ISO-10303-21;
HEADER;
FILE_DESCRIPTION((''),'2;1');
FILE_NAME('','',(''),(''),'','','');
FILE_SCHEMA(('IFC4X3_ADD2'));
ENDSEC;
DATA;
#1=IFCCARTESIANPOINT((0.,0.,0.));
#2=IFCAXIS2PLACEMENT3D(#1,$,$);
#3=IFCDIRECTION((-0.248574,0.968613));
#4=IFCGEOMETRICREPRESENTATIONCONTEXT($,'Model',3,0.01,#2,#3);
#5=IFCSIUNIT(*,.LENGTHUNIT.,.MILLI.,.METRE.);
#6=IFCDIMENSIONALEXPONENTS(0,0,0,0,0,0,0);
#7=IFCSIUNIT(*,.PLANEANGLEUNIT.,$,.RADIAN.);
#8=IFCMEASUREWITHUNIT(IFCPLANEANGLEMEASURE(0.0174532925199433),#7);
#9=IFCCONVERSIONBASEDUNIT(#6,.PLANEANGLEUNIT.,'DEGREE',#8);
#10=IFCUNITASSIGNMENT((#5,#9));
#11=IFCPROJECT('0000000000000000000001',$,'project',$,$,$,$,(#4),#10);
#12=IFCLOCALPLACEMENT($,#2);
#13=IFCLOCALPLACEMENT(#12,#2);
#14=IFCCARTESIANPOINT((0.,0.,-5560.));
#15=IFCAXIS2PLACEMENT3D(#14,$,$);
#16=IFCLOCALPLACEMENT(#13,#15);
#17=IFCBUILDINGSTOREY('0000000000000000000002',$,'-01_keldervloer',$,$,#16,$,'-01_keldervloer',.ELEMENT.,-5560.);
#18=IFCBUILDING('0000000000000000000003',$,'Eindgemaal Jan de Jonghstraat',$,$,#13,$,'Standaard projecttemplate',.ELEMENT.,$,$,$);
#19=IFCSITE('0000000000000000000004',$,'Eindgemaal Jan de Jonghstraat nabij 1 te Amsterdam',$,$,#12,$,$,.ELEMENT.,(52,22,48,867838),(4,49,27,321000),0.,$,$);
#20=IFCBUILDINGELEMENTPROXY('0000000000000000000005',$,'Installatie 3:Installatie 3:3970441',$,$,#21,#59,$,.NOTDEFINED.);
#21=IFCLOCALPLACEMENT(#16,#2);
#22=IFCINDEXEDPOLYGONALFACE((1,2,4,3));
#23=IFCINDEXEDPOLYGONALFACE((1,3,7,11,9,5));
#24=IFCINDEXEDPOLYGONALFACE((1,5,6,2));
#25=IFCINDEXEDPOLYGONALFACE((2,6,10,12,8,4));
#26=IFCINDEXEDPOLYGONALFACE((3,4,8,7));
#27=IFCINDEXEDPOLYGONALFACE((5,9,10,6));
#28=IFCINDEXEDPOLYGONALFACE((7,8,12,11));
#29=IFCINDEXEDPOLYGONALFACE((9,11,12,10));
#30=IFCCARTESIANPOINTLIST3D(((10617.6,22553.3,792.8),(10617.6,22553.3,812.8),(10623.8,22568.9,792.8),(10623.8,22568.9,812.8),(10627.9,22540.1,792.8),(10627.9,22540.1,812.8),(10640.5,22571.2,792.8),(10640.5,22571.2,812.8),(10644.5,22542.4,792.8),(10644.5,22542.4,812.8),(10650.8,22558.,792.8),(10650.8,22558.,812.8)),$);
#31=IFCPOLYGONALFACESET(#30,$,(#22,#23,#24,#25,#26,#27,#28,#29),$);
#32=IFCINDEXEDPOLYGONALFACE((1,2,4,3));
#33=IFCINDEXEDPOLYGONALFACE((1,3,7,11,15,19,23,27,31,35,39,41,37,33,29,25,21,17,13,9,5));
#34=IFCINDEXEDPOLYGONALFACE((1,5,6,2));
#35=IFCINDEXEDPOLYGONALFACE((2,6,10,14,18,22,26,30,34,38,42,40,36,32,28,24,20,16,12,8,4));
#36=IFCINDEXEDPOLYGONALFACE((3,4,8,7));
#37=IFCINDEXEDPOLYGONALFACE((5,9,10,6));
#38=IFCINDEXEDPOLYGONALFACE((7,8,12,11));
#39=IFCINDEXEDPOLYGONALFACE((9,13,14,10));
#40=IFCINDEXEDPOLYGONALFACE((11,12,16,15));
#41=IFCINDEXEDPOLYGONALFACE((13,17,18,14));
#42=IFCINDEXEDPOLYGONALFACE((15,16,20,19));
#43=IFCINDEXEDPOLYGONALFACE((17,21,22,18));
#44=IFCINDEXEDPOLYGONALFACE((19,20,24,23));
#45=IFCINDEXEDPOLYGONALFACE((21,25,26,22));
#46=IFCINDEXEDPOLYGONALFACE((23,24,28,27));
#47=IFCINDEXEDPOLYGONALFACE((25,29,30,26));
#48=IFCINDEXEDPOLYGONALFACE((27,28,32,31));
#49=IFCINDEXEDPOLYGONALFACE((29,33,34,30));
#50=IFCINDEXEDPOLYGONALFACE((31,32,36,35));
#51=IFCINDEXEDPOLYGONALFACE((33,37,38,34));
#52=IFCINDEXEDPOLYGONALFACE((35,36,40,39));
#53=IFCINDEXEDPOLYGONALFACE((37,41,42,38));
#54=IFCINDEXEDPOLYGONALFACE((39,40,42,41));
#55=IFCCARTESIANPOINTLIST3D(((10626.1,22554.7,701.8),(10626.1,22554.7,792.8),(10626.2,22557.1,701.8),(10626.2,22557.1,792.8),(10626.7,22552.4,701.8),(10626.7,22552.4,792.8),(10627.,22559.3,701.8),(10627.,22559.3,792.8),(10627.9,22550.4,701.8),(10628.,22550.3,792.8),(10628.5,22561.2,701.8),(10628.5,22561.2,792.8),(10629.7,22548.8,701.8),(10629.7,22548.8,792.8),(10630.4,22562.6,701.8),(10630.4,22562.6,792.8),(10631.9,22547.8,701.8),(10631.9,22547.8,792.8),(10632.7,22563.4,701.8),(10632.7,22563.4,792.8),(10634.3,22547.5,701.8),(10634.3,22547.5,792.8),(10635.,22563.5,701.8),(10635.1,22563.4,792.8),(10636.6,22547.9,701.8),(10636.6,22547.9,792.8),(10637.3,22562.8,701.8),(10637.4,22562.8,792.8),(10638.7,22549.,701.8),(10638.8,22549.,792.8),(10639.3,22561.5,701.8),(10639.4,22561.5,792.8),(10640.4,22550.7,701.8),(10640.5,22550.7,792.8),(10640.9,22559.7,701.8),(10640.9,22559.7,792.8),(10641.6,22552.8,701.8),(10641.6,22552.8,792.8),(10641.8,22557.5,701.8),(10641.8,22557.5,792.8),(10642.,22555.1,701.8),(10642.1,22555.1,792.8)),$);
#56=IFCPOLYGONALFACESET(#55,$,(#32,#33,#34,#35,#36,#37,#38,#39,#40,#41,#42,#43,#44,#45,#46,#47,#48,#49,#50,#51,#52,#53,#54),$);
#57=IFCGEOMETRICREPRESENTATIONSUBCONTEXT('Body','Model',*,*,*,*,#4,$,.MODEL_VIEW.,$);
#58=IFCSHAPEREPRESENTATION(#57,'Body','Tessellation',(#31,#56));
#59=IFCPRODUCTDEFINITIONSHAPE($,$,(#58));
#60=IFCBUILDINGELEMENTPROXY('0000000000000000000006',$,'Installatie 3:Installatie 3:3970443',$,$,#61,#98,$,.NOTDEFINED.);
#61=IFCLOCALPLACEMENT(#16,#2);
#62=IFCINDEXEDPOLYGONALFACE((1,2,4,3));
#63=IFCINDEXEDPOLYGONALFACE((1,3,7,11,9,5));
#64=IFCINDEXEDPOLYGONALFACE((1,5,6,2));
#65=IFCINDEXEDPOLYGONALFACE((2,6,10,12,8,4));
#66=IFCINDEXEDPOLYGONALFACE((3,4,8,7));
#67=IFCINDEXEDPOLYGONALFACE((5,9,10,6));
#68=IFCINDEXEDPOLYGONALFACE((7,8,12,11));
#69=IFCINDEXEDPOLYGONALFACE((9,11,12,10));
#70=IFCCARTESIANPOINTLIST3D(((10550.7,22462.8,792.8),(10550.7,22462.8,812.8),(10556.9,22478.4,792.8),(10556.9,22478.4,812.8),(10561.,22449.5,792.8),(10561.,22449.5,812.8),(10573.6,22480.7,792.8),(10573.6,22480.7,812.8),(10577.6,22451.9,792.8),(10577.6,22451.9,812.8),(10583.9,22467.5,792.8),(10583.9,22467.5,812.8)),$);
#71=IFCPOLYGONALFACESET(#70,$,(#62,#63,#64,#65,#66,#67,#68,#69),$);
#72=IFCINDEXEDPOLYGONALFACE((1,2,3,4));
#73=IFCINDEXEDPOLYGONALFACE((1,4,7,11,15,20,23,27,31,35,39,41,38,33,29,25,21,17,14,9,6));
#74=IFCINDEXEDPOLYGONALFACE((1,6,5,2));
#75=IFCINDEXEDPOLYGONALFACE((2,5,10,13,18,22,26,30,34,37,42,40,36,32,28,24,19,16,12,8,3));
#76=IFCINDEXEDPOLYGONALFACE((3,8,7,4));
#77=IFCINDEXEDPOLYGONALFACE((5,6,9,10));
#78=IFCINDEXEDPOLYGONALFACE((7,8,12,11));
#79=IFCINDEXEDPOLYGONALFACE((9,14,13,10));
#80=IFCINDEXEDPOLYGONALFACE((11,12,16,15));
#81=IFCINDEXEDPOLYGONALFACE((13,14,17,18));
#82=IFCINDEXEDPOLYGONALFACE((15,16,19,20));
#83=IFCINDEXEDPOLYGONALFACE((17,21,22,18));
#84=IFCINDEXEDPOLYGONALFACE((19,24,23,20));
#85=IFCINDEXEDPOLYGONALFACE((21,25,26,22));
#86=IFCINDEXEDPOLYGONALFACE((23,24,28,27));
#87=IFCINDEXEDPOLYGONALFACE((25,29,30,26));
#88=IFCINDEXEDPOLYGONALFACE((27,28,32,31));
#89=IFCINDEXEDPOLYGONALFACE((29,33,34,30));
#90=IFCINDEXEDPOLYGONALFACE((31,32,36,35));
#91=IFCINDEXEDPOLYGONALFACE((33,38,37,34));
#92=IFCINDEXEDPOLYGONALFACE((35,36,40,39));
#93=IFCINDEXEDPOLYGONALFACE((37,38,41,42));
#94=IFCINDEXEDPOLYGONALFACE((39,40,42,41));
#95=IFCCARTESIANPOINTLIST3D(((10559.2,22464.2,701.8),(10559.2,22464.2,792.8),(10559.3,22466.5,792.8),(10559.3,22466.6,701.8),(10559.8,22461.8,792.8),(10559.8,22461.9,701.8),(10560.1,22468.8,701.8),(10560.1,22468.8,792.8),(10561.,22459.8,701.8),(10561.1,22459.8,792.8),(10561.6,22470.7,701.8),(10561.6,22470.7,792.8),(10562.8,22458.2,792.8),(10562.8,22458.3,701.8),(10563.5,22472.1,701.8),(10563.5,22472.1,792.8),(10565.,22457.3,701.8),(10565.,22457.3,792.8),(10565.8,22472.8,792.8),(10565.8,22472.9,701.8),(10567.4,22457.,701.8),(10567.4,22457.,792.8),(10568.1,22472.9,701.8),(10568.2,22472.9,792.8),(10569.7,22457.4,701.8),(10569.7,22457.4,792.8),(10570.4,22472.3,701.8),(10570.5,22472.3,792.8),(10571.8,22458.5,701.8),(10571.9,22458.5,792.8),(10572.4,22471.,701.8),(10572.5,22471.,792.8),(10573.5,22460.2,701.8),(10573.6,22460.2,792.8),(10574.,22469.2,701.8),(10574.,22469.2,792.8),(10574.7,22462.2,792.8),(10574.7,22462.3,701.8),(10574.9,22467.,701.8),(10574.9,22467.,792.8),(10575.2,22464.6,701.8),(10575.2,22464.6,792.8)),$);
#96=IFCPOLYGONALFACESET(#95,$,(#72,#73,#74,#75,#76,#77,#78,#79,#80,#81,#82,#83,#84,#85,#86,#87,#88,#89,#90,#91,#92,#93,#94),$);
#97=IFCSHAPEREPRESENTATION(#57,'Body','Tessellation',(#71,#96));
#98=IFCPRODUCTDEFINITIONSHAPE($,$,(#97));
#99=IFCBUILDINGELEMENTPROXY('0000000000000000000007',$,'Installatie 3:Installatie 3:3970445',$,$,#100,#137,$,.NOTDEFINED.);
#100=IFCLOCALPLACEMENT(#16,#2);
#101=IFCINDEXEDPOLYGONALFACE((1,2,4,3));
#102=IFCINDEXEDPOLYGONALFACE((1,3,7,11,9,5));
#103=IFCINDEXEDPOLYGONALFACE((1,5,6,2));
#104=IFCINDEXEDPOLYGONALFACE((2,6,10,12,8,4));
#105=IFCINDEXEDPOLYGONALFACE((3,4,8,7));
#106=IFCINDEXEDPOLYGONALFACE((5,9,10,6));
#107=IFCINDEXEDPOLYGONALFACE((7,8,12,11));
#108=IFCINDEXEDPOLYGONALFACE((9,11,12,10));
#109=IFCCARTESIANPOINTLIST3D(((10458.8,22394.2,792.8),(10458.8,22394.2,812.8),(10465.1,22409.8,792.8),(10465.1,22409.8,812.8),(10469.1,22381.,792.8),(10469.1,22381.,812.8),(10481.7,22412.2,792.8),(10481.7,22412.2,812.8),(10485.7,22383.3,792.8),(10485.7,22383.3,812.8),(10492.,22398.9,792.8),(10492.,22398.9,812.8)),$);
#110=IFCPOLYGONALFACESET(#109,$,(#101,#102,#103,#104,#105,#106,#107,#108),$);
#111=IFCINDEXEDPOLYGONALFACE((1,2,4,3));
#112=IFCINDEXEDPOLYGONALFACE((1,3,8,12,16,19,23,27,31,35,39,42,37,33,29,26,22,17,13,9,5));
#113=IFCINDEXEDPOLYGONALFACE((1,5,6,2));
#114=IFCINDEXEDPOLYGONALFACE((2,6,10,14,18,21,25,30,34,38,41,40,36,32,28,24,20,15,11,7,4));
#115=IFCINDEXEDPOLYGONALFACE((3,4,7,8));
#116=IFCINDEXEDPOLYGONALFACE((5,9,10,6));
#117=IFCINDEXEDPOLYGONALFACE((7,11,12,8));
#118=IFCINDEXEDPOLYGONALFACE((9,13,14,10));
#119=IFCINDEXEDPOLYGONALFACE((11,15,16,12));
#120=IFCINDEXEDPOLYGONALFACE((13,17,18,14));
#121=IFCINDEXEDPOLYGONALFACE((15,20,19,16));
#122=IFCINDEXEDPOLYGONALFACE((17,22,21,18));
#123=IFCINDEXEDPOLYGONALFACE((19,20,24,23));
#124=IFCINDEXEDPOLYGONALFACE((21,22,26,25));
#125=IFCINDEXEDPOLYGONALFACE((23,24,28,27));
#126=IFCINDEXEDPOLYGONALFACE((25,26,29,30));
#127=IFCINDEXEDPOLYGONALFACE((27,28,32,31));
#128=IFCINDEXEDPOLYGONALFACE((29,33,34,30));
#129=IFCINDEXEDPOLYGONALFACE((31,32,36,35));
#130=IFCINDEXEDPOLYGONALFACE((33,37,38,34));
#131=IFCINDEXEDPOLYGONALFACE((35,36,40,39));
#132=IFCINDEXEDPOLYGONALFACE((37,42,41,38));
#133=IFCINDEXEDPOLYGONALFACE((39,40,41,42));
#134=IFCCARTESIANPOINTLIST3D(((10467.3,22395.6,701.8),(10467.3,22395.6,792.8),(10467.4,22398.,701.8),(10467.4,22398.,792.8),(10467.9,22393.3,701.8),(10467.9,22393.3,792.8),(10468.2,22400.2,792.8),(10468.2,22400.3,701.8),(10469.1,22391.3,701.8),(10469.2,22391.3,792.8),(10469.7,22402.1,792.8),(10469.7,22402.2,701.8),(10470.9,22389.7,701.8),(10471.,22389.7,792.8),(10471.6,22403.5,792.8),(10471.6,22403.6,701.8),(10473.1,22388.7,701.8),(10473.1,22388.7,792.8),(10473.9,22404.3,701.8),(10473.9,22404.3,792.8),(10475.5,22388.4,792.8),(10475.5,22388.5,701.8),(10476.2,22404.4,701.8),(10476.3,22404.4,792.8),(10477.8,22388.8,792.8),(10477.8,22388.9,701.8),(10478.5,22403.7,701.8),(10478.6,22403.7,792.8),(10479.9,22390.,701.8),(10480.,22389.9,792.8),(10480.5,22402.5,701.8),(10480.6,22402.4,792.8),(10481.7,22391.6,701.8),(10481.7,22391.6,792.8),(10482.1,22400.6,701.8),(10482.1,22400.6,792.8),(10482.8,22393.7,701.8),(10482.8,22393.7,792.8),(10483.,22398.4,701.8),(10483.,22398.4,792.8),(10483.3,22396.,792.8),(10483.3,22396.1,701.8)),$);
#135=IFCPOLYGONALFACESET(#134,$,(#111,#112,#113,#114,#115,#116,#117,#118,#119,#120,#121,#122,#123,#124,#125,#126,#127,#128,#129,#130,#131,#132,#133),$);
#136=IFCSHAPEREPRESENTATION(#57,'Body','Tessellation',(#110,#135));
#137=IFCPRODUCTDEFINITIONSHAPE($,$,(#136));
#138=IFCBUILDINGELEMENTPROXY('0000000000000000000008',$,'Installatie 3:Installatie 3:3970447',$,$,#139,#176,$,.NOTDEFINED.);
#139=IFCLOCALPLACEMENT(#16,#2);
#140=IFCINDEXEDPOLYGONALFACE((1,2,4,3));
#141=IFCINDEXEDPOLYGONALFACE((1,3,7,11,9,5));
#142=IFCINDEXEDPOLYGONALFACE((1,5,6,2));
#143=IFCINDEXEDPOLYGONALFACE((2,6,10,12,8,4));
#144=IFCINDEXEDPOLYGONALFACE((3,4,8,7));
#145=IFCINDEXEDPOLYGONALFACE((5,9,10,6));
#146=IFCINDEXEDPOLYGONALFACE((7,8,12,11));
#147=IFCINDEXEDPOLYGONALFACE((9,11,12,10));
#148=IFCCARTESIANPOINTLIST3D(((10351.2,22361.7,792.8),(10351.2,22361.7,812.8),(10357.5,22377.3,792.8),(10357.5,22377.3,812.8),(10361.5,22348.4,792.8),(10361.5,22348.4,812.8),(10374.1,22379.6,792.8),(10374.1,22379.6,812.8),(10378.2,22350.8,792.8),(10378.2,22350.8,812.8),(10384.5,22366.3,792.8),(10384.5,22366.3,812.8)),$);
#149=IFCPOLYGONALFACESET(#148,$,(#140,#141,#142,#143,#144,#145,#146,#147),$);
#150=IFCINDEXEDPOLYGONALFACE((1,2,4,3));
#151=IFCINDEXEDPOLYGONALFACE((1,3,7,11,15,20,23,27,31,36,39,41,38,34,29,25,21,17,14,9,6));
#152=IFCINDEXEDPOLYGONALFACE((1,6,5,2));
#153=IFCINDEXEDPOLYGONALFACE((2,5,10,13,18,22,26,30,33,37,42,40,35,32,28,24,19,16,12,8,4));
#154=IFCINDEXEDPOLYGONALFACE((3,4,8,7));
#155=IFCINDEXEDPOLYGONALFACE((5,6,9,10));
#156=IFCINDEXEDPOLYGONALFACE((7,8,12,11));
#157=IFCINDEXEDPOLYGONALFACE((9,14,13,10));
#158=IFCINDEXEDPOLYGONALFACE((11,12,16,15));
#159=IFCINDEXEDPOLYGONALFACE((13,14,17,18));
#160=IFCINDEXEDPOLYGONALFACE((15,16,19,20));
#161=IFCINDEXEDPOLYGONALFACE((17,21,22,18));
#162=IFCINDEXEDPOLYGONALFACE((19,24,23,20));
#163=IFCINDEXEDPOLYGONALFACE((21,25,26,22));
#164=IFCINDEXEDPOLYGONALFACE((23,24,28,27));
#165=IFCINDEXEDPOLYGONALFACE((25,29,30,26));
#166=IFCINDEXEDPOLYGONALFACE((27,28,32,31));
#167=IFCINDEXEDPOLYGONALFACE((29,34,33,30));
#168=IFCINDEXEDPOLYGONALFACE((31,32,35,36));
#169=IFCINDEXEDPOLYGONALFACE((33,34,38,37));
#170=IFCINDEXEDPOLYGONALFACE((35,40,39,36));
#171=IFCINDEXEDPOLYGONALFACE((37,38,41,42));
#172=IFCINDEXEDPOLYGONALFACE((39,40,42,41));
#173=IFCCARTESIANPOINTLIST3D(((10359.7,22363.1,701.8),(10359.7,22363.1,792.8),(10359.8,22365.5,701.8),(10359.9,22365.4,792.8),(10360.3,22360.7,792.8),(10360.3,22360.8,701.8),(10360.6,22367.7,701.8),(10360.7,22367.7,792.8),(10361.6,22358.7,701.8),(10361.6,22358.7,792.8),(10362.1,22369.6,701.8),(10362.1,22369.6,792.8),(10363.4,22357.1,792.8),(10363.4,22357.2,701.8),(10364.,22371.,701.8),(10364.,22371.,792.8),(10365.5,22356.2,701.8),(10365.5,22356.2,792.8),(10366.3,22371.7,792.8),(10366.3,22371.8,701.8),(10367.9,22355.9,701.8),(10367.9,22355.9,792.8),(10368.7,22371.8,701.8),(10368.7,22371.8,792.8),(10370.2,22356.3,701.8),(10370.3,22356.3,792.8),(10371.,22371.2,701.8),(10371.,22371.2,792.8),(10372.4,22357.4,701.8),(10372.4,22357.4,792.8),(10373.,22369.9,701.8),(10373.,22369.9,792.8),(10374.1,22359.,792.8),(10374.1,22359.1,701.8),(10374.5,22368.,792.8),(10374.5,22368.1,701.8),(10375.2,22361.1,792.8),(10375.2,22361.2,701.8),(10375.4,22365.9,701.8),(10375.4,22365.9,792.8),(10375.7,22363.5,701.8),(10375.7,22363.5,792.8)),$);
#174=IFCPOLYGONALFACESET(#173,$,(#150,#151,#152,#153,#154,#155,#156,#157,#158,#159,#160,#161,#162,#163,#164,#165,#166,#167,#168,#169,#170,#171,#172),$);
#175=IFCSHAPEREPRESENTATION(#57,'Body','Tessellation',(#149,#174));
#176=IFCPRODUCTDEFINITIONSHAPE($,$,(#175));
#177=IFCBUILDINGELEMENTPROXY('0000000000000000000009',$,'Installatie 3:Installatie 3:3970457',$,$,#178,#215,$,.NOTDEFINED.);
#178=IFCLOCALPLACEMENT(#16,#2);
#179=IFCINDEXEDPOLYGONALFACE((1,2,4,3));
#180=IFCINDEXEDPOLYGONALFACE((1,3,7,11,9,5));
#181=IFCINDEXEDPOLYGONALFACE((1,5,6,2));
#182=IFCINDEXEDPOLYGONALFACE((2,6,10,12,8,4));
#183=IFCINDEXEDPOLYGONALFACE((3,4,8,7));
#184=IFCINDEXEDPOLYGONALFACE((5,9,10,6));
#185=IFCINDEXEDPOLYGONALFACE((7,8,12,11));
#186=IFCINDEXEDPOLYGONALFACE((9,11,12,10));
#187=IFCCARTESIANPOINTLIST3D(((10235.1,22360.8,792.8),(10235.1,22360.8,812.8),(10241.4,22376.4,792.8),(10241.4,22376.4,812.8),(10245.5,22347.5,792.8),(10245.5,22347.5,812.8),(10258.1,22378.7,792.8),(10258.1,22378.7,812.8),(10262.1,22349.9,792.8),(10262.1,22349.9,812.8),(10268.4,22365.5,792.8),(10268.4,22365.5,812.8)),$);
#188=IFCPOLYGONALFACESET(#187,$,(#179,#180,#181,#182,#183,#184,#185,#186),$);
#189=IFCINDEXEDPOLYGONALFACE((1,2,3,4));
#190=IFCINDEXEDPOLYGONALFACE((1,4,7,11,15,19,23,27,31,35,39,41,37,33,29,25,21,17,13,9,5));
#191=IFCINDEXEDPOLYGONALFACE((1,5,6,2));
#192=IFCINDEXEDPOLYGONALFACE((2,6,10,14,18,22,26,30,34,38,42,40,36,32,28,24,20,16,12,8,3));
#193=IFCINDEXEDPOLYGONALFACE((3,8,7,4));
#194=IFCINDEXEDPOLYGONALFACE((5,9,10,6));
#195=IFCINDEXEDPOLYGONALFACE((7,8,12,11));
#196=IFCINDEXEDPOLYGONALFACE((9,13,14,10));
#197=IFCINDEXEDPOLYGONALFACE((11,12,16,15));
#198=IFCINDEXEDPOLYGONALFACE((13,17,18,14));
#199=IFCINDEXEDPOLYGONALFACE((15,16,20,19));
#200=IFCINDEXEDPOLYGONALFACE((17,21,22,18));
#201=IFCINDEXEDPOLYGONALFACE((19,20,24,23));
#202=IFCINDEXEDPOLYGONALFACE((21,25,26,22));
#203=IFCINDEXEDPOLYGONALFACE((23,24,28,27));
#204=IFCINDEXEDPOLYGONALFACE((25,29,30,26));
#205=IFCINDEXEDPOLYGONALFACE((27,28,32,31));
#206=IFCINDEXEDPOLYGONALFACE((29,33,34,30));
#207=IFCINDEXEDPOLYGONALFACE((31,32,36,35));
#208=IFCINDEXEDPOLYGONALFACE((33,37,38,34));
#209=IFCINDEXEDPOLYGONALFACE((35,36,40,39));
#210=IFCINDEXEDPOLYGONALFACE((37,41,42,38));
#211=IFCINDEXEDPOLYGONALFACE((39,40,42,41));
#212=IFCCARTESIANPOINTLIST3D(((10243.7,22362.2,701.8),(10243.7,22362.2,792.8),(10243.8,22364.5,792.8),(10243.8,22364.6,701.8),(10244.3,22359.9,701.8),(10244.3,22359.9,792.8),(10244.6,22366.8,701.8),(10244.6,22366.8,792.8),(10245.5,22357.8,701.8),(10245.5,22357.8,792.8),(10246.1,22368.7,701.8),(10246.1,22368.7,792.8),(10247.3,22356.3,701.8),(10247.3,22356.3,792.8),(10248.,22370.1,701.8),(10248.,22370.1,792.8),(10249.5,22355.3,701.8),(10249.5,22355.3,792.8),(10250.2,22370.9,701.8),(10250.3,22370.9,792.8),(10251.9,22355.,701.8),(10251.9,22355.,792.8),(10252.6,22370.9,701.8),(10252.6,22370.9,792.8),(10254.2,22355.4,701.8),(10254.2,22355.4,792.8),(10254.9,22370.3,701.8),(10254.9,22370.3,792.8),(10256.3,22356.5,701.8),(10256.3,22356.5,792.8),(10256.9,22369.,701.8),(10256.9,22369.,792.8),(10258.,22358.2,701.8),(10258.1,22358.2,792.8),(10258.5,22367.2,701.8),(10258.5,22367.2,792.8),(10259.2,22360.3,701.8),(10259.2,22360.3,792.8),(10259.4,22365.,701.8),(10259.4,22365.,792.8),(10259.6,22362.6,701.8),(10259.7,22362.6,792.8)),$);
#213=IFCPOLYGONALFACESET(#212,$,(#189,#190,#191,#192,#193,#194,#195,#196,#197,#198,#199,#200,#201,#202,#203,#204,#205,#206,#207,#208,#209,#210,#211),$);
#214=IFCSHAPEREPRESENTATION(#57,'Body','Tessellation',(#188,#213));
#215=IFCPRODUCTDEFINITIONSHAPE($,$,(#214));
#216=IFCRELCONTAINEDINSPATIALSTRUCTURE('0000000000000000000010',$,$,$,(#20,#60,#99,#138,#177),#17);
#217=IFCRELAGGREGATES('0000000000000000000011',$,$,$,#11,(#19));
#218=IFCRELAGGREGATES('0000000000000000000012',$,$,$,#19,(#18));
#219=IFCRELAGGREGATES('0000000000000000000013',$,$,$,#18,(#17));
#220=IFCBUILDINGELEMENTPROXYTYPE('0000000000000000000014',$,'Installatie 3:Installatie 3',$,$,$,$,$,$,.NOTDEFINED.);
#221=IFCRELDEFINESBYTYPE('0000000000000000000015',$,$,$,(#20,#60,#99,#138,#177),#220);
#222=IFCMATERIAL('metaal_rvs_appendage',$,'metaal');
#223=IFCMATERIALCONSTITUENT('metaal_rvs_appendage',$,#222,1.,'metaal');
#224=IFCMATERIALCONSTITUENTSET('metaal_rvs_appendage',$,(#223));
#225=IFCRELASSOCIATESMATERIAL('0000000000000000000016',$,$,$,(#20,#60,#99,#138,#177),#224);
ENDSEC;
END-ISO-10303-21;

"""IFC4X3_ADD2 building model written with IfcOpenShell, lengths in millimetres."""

from ifc_helpers import new_model, entity, si_unit, converted_unit, direction, frame, frame_2d, origin, place, context, subcontext, project, spatial, polyline, circle, outline, extrude, source, transform, mapped, material, constituent, constituent_set, type_object, type_shapes, element, save


model = new_model("IFC4X3_ADD2")

# Units and contexts
model_context = context("Model", 3, precision=0.01, world=origin(), true_north=direction((-0.248574, 0.968613)))
body_context = subcontext(model_context, "Body", "Model", "MODEL_VIEW")
ifc_project = project(units=[si_unit("LENGTHUNIT", "METRE", prefix="MILLI"), converted_unit("PLANEANGLEUNIT", "DEGREE", entity("IfcPlaneAngleMeasure", 0.0174532925199433), si_unit("PLANEANGLEUNIT", "RADIAN"), dimensions=[0, 0, 0, 0, 0, 0, 0])], contexts=[model_context])

# Site, building, storey
site_placement = place(None, origin())
site = spatial("IfcSite", under=ifc_project, at=site_placement, Name="Eindgemaal Jan de Jonghstraat nabij 1 te Amsterdam", CompositionType="ELEMENT", RefLatitude=(52, 22, 48, 867838), RefLongitude=(4, 49, 27, 321000), RefElevation=0.0)
building_placement = place(site_placement, origin())
building = spatial("IfcBuilding", under=site, at=building_placement, Name="Eindgemaal Jan de Jonghstraat", LongName="Standaard projecttemplate", CompositionType="ELEMENT")
storey_placement = place(building_placement, frame((0.0, 0.0, -5560.0)))
storey = spatial("IfcBuildingStorey", under=building, at=storey_placement, Name="-01_keldervloer", LongName="-01_keldervloer", CompositionType="ELEMENT", Elevation=-5560.0)

# Building element proxies
ifc_material_1 = material(Name="metaal_rvs_appendage", Category="metaal")
ifc_constituent_1 = constituent(ifc_material_1, Name="metaal_rvs_appendage", Category="metaal", fraction=1.0)
ifc_constituent_set_1 = constituent_set(constituents=[ifc_constituent_1], Name="metaal_rvs_appendage")
building_element_proxy_type_1 = type_object("IfcBuildingElementProxyType", Name="Installatie 3:Installatie 3", PredefinedType="NOTDEFINED")
shared_shape_1 = source(origin(), body_context, "Body", "SweptSolid", [
    extrude(outline(polyline([(-8.4, -14.6), (8.4, -14.6), (16.8, 0.0), (8.4, 14.6), (-8.4, 14.6), (-16.8, 0.0), (-8.4, -14.6)])), frame((0.0, 0.0, 41.5), z_axis=(0.0, 0.0, 1.0), x_axis=(-0.400458, 0.916315, 0.0)), (0.0, 0.0, 1.0), 20.0),
    extrude(circle(Radius=8.0, at=frame_2d((0.0, 0.0), x_axis=(1.0, 0.0))), frame((-0.2, -0.1, -49.5), z_axis=(0.000101, -0.000286, 1.0), x_axis=(1.0, 0.0, -0.000101)), (0.0, 0.0, 1.0), 91.1),
])
type_shapes(building_element_proxy_type_1, [shared_shape_1])
for number, where, z_axis, x_axis, name in (
    (1, (10634.2, 22555.6, 751.3), (0.0, 0.0, 1.0), (0.968613, 0.248574, 0.0), "Installatie 3:Installatie 3:3970441"),
    (2, (10567.3, 22465.1, 751.3), (0.0, 0.0, 1.0), (0.968613, 0.248574, 0.0), "Installatie 3:Installatie 3:3970443"),
    (3, (10475.4, 22396.6, 751.3), (0.0, 0.0, 1.0), (0.968613, 0.248574, 0.0), "Installatie 3:Installatie 3:3970445"),
    (4, (10367.8, 22364.0, 751.3), (0.0, 0.0, 1.0), (0.968613, 0.248574, 0.0), "Installatie 3:Installatie 3:3970447"),
    (5, (10251.8, 22363.1, 751.3), (0.0, 0.0, 1.0), (0.968613, 0.248574, 0.0), "Installatie 3:Installatie 3:3970457"),
):
    element("IfcBuildingElementProxy", number, at=place(storey_placement, frame(where, z_axis=z_axis, x_axis=x_axis)), inside=storey, type_object=building_element_proxy_type_1, material=ifc_constituent_set_1, Name=name, PredefinedType="NOTDEFINED", context=body_context, shape_type="MappedRepresentation", body=[
        mapped(shared_shape_1, transform((0.0, 0.0, 0.0), scale=1.0)),
    ])

save(model, "model.ifc")
